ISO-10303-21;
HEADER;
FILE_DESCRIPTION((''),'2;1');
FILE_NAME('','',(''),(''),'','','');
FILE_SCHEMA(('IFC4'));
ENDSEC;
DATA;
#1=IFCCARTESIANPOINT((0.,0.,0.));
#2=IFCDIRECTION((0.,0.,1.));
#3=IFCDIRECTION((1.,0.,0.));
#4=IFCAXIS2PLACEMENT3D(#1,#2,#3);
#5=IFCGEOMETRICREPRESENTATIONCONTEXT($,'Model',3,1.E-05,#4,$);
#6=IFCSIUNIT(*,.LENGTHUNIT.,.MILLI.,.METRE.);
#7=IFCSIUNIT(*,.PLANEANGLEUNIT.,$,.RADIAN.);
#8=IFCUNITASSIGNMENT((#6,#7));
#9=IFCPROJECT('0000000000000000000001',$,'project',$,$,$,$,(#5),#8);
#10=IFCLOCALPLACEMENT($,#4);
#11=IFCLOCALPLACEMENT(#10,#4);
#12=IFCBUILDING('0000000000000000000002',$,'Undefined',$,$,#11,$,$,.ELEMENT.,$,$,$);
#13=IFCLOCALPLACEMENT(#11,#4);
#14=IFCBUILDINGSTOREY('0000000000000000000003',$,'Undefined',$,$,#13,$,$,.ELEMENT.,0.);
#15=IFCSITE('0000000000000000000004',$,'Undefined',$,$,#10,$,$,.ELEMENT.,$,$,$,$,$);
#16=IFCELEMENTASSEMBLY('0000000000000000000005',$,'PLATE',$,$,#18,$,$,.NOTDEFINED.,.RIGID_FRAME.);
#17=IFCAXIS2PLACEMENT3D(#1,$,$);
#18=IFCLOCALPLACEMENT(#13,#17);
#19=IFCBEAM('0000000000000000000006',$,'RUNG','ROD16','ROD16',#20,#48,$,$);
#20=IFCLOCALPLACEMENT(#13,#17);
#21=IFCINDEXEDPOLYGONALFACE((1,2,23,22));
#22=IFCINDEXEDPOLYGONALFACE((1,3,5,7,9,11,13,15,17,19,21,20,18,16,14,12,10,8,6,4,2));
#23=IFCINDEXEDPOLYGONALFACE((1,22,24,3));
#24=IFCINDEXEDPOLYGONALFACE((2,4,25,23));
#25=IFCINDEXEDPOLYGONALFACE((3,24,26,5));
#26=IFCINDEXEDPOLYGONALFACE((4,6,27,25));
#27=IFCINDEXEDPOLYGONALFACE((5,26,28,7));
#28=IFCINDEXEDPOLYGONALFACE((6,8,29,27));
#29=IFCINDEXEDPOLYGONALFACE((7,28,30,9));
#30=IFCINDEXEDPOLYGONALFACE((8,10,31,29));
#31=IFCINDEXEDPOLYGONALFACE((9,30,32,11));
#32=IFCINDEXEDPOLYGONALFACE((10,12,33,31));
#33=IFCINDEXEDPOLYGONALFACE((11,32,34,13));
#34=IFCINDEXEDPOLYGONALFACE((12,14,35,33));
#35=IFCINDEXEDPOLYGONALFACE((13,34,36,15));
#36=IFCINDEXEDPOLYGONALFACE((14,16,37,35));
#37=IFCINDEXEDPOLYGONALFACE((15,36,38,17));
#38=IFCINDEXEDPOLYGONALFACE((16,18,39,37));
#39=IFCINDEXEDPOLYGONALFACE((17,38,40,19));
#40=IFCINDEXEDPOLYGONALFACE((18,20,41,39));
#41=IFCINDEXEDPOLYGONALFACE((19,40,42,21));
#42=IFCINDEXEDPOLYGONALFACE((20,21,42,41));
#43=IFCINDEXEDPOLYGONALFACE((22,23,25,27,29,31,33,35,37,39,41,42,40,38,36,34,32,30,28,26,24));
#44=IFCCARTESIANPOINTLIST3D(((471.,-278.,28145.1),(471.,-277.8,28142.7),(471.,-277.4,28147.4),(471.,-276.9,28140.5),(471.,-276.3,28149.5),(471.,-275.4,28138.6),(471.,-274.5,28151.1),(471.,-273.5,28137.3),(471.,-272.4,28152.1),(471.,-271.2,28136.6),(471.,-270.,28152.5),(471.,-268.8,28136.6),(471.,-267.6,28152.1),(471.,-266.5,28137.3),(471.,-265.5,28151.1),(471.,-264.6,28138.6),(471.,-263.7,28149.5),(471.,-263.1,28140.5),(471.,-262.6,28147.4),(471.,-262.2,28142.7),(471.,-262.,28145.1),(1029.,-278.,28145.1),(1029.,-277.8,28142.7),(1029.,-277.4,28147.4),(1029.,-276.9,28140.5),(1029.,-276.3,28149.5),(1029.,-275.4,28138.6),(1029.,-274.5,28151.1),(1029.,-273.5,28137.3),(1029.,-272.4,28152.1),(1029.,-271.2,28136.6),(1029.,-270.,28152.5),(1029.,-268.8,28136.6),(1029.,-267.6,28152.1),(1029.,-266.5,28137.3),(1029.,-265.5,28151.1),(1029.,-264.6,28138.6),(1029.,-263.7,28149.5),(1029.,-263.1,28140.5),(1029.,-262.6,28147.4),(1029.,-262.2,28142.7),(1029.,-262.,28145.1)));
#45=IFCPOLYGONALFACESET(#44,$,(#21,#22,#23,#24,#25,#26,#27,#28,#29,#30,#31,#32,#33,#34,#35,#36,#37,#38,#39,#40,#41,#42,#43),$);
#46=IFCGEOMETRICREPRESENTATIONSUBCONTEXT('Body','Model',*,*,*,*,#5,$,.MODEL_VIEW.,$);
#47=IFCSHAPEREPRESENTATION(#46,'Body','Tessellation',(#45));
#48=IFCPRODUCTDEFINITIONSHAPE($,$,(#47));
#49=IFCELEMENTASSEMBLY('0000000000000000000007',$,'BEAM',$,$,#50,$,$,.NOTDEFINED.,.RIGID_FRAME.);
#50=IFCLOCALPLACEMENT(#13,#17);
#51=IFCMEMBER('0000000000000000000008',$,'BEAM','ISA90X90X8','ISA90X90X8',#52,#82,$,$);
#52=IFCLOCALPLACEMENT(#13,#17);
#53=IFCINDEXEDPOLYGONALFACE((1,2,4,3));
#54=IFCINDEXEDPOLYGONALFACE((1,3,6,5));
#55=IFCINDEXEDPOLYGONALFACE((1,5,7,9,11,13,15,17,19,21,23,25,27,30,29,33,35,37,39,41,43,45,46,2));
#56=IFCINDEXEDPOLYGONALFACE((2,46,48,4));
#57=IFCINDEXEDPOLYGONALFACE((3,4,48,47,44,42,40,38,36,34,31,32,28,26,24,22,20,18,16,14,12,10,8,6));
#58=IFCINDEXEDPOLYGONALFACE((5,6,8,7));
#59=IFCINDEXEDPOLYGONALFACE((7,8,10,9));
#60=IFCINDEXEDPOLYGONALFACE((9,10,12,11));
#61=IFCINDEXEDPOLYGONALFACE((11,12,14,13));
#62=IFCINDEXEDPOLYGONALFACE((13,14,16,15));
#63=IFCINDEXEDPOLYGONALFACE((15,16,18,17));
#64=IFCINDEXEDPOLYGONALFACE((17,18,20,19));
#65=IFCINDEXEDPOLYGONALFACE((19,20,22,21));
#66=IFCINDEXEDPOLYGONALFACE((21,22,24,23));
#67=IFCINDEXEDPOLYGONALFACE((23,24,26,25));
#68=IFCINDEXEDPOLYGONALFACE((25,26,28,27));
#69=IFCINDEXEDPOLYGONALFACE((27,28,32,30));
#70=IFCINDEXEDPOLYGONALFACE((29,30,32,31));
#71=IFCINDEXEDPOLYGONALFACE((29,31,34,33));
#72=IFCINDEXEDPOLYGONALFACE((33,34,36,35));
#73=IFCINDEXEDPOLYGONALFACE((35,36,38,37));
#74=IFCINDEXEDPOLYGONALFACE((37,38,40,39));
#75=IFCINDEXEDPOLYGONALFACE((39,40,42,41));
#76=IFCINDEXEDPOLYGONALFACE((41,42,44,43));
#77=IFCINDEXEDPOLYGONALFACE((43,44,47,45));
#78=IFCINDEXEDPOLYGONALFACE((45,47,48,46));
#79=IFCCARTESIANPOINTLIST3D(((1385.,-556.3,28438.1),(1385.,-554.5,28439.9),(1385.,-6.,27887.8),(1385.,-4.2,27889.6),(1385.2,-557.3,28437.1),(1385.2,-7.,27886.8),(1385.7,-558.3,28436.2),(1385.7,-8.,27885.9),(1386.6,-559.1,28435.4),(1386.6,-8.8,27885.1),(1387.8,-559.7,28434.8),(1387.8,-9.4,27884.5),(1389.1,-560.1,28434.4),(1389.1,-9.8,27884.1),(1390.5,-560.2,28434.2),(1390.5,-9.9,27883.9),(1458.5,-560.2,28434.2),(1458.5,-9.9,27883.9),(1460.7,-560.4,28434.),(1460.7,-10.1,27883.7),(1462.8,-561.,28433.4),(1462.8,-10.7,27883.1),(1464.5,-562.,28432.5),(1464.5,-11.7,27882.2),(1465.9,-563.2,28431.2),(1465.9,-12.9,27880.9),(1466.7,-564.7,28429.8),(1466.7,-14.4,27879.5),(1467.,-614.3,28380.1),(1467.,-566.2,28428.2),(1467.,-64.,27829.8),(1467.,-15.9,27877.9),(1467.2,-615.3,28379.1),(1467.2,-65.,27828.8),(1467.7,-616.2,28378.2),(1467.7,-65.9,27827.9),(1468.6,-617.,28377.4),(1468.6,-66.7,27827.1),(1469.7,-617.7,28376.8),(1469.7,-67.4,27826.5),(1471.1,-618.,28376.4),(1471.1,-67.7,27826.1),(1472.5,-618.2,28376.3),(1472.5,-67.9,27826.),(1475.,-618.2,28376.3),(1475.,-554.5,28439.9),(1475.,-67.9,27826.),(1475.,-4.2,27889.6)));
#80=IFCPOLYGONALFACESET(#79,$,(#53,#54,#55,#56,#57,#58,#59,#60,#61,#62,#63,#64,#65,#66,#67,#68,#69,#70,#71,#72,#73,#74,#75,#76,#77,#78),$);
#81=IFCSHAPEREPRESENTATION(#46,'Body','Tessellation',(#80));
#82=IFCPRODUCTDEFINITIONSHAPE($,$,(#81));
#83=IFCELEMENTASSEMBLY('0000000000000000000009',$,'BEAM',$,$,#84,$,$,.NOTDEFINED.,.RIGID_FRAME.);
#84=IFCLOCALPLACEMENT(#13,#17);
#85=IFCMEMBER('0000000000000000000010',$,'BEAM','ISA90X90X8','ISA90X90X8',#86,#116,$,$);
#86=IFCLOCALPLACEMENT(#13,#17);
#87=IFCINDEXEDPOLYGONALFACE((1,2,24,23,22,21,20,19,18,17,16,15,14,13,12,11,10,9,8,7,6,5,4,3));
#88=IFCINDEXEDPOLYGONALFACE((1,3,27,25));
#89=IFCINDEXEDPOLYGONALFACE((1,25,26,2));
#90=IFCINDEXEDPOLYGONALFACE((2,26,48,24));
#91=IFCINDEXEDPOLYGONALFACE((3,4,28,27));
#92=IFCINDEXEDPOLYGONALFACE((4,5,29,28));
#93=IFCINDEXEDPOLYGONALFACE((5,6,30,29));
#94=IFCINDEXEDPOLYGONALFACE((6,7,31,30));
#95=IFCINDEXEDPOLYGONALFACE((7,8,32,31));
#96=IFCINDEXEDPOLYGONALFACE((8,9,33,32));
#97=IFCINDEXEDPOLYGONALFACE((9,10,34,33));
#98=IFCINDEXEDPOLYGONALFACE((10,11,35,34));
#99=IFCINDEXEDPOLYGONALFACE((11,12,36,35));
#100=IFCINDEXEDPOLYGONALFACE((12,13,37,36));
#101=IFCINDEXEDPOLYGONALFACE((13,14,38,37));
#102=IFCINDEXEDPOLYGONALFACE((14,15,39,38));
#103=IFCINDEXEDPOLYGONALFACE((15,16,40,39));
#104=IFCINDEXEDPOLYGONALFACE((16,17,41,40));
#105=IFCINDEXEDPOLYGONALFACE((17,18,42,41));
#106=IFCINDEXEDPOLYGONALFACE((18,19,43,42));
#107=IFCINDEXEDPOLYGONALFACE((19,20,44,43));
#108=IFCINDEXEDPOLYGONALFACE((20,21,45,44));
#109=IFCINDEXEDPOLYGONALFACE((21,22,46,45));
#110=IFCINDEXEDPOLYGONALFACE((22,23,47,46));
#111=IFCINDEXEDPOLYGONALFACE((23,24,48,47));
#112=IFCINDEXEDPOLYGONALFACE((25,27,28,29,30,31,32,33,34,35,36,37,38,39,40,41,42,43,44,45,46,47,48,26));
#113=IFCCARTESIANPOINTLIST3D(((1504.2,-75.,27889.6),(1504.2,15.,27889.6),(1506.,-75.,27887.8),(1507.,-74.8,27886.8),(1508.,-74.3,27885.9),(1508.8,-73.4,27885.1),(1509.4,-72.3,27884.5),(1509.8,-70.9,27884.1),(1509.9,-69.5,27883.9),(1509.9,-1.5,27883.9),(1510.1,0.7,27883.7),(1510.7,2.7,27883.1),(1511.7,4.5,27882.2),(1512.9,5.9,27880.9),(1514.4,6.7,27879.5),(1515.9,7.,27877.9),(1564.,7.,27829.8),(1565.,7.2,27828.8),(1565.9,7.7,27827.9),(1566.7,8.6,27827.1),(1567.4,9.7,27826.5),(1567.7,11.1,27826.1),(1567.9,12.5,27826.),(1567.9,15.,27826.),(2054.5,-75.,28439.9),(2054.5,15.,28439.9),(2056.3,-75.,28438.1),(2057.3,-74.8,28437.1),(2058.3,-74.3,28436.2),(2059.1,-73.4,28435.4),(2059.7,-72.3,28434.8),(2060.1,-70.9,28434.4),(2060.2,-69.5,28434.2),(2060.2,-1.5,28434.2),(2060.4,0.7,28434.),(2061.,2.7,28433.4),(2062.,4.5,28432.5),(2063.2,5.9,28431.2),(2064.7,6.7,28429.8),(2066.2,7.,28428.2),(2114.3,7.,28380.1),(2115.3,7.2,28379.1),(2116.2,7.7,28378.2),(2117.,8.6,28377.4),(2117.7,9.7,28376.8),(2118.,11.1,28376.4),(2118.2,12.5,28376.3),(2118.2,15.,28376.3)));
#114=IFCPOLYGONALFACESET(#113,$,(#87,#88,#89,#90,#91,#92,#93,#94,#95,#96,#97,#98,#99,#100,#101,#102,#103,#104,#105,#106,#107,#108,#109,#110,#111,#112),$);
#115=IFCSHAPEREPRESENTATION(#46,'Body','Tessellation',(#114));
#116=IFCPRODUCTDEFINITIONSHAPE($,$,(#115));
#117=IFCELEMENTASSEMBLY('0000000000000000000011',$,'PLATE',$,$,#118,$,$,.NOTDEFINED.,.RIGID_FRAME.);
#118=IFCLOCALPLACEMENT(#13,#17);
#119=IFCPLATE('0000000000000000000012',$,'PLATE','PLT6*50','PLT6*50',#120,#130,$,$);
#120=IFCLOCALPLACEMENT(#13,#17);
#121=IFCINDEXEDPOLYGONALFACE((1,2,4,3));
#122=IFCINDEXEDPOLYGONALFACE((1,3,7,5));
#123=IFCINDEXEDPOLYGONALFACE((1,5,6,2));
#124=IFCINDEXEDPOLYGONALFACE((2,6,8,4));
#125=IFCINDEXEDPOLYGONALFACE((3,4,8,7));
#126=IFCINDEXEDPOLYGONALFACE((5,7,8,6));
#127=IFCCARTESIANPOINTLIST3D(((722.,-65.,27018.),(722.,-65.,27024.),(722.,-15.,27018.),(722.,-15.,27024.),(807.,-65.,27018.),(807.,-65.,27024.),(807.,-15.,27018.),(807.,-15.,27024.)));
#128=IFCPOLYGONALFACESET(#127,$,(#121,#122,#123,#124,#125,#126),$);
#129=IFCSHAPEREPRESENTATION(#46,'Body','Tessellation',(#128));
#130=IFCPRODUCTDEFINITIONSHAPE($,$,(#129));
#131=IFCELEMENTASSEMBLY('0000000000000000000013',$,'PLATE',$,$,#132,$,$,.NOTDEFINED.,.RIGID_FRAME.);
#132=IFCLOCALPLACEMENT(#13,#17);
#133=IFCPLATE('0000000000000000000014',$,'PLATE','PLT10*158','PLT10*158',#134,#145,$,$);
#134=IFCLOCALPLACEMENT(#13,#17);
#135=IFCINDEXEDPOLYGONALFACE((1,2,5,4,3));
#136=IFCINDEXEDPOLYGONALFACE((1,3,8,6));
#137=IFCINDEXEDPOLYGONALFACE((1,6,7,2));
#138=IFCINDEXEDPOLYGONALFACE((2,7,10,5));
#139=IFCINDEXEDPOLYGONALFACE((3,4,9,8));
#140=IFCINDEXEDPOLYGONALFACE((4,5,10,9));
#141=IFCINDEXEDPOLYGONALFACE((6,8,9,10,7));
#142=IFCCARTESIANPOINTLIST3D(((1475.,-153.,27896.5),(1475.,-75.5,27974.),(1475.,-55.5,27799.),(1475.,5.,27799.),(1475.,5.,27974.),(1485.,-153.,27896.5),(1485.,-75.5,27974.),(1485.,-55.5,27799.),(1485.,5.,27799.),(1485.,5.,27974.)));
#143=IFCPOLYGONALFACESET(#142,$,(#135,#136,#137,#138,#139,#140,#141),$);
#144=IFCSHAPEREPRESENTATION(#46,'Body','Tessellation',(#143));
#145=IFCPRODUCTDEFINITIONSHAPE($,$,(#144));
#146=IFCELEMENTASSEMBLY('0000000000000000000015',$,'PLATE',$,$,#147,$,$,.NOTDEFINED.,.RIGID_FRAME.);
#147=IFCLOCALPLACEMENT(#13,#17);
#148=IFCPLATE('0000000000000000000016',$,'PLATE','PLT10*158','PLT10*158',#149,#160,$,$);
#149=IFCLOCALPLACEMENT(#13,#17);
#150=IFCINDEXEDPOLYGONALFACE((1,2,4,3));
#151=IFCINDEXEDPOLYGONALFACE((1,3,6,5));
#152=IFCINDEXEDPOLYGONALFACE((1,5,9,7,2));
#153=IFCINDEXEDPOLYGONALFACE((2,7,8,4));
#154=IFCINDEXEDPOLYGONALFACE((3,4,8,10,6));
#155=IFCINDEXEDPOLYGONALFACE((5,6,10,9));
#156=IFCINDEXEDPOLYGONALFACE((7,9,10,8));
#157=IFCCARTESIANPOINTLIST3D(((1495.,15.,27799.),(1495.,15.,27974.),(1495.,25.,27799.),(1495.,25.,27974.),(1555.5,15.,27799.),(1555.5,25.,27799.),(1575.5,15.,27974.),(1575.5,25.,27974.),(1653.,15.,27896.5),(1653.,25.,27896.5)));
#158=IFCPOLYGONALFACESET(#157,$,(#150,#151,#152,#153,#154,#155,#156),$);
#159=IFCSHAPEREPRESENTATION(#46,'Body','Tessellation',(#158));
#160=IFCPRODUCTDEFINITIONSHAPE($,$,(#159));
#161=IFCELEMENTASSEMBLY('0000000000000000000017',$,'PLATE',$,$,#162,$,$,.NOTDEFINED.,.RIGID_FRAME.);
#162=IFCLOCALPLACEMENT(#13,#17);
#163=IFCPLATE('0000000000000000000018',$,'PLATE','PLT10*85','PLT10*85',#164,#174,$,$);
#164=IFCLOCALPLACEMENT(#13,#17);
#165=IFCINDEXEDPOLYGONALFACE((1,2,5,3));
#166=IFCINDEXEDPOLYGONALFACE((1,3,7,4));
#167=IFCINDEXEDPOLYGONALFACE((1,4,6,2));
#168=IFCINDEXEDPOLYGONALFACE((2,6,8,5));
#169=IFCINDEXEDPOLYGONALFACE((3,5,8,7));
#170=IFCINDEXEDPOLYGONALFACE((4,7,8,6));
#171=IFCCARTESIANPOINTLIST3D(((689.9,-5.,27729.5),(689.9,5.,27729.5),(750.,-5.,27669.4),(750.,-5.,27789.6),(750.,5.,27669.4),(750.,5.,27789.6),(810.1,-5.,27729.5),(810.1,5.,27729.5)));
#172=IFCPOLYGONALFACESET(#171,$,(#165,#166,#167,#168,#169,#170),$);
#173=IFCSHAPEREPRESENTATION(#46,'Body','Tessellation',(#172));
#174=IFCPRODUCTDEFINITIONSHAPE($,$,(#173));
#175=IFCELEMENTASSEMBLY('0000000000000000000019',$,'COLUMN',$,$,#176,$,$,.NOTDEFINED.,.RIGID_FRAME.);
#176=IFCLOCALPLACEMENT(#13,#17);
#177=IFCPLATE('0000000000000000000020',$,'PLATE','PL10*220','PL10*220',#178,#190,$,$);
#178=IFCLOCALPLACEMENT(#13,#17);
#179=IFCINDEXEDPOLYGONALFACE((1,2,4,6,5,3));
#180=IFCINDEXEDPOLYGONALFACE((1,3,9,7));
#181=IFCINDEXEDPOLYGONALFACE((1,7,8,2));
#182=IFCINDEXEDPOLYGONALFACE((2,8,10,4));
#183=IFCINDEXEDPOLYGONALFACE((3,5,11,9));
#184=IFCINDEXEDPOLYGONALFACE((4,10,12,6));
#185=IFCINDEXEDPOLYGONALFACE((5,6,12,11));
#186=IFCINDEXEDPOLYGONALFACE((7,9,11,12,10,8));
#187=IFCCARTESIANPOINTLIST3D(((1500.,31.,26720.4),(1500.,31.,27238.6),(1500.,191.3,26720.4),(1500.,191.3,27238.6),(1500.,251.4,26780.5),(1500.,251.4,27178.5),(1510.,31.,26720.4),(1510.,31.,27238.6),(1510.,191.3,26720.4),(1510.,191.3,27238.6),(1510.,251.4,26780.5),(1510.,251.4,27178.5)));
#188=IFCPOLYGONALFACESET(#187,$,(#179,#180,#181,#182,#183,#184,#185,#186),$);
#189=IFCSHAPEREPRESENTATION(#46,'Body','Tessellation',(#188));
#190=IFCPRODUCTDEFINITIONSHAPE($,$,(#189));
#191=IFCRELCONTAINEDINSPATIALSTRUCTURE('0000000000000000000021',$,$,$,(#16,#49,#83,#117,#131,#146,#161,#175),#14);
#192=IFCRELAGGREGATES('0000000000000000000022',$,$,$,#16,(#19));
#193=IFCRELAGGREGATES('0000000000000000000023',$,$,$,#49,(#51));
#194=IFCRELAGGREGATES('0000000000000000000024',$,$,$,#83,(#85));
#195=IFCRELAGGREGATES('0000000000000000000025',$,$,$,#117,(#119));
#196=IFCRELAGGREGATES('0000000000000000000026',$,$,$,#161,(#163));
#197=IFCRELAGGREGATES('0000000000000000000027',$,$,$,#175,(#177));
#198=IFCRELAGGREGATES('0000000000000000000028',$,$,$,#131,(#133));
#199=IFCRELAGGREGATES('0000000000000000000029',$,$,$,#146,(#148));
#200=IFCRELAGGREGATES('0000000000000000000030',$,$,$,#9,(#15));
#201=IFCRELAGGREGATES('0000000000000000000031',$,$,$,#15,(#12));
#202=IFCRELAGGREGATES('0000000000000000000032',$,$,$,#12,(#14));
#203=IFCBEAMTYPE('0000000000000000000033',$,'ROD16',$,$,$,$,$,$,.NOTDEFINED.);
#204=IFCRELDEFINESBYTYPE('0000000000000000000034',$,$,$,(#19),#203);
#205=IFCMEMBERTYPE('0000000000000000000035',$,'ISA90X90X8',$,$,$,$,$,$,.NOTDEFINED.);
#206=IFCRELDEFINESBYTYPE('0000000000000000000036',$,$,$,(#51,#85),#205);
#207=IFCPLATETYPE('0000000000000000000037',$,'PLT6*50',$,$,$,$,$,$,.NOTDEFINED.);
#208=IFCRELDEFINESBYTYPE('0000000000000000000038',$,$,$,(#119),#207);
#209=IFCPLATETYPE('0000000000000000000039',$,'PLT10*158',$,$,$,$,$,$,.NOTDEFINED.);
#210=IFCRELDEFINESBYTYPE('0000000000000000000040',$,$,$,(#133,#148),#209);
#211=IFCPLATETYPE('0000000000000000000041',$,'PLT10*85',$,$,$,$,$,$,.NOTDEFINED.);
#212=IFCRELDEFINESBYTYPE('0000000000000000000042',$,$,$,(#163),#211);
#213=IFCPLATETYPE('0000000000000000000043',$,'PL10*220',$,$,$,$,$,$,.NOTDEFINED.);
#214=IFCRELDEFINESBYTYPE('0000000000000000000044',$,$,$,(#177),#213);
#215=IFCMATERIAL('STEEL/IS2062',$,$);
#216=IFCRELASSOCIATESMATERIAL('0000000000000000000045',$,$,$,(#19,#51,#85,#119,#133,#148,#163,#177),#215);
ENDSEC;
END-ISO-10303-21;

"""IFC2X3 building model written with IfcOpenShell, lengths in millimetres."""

from ifc_helpers import new_model, si_unit, frame, origin_with_axes, origin_2d_with_axis, place, context, subcontext, project, spatial, polyline, circle, l_section, outline, extrude, material, type_object, element, aggregate, save


model = new_model("IFC2X3")

# Units and contexts
model_context = context("Model", 3, precision=1e-05, world=origin_with_axes())
body_context = subcontext(model_context, "Body", "Model", "MODEL_VIEW")
ifc_project = project(units=[si_unit("LENGTHUNIT", "METRE", prefix="MILLI"), si_unit("PLANEANGLEUNIT", "RADIAN")], contexts=[model_context])

# Site, building, storey
site_placement = place(None, origin_with_axes())
site = spatial("IfcSite", under=ifc_project, at=site_placement, Name="Undefined", CompositionType="ELEMENT")
building_placement = place(site_placement, origin_with_axes())
building = spatial("IfcBuilding", under=site, at=building_placement, Name="Undefined", CompositionType="ELEMENT")
storey_placement = place(building_placement, origin_with_axes())
storey = spatial("IfcBuildingStorey", under=building, at=storey_placement, Name="Undefined", CompositionType="ELEMENT", Elevation=0.0)

# Shared definitions
ifc_material_1 = material(Name="STEEL/IS2062")

# Element assembly, beam
assembly_1_placement = place(storey_placement, origin_with_axes())
assembly_1 = element("IfcElementAssembly", 1, at=assembly_1_placement, inside=storey, Name="PLATE", AssemblyPlace="NOTDEFINED", PredefinedType="RIGID_FRAME")
beam_type_1 = type_object("IfcBeamType", Name="ROD16", PredefinedType="NOTDEFINED")
beam_1_placement = place(assembly_1_placement, frame((471.0, -270.0, 28144.5), z_axis=(0.0, 1.0, 0.0), x_axis=(1.0, 0.0, 0.0)))
beam_1 = element("IfcBeam", 2, at=beam_1_placement, type_object=beam_type_1, material=ifc_material_1, Name="RUNG", Description="ROD16", ObjectType="ROD16", context=body_context, shape_type="SweptSolid", body=[
    extrude(circle(Radius=8.0, at=origin_2d_with_axis()), frame((558.0, 0.0, 0.0), z_axis=(-1.0, 0.0, 0.0), x_axis=(0.0, -1.0, 0.0)), (0.0, 0.0, 1.0), 558.0),
])
aggregate(assembly_1, [beam_1])

# Element assemblies, members
assembly_2_placement = place(storey_placement, origin_with_axes())
assembly_2 = element("IfcElementAssembly", 3, at=assembly_2_placement, inside=storey, Name="BEAM", AssemblyPlace="NOTDEFINED", PredefinedType="RIGID_FRAME")
member_type_1 = type_object("IfcMemberType", Name="ISA90X90X8", PredefinedType="NOTDEFINED")
member_1_placement = place(assembly_2_placement, frame((1430.0, -36.1, 27857.8), z_axis=(-1.0, 0.0, 0.0), x_axis=(0.0, -0.707107, 0.707107)))
member_1 = element("IfcMember", 4, at=member_1_placement, type_object=member_type_1, material=ifc_material_1, Name="BEAM", Description="ISA90X90X8", ObjectType="ISA90X90X8", context=body_context, shape_type="SweptSolid", body=[
    extrude(l_section(Depth=90.0, Width=90.0, Thickness=8.0, FilletRadius=8.5, EdgeRadius=5.5, at=origin_2d_with_axis()), frame((778.2, 0.0, 0.0), z_axis=(-1.0, 0.0, 0.0), x_axis=(0.0, -1.0, 0.0)), (0.0, 0.0, 1.0), 778.2),
])
aggregate(assembly_2, [member_1])
assembly_3_placement = place(storey_placement, origin_with_axes())
assembly_3 = element("IfcElementAssembly", 5, at=assembly_3_placement, inside=storey, Name="BEAM", AssemblyPlace="NOTDEFINED", PredefinedType="RIGID_FRAME")
member_2_placement = place(assembly_3_placement, frame((1536.1, -30.0, 27857.8), z_axis=(0.0, -1.0, 0.0), x_axis=(0.707107, 0.0, 0.707107)))
member_2 = element("IfcMember", 6, at=member_2_placement, type_object=member_type_1, material=ifc_material_1, Name="BEAM", Description="ISA90X90X8", ObjectType="ISA90X90X8", context=body_context, shape_type="SweptSolid", body=[
    extrude(l_section(Depth=90.0, Width=90.0, Thickness=8.0, FilletRadius=8.5, EdgeRadius=5.5, at=origin_2d_with_axis()), frame((778.2, 0.0, 0.0), z_axis=(-1.0, 0.0, 0.0), x_axis=(0.0, -1.0, 0.0)), (0.0, 0.0, 1.0), 778.2),
])
aggregate(assembly_3, [member_2])

# Element assemblies, plates
assembly_4_placement = place(storey_placement, origin_with_axes())
assembly_4 = element("IfcElementAssembly", 7, at=assembly_4_placement, inside=storey, Name="PLATE", AssemblyPlace="NOTDEFINED", PredefinedType="RIGID_FRAME")
plate_type_1 = type_object("IfcPlateType", Name="PLT6*50", PredefinedType="NOTDEFINED")
plate_1_placement = place(assembly_4_placement, frame((807.0, -65.0, 27021.0), z_axis=(0.0, 0.0, -1.0), x_axis=(-1.0, 0.0, 0.0)))
plate_1 = element("IfcPlate", 8, at=plate_1_placement, type_object=plate_type_1, material=ifc_material_1, Name="PLATE", Description="PLT6*50", ObjectType="PLT6*50", context=body_context, shape_type="SweptSolid", body=[
    extrude(outline(polyline([(0.0, 0.0), (85.0, 0.0), (85.0, 50.0), (0.0, 50.0), (0.0, 0.0)])), frame((0.0, 0.0, -3.0), z_axis=(0.0, 0.0, 1.0), x_axis=(1.0, 0.0, 0.0)), (0.0, 0.0, 1.0), 6.0),
])
aggregate(assembly_4, [plate_1])
assembly_5_placement = place(storey_placement, origin_with_axes())
assembly_5 = element("IfcElementAssembly", 9, at=assembly_5_placement, inside=storey, Name="PLATE", AssemblyPlace="NOTDEFINED", PredefinedType="RIGID_FRAME")
plate_type_2 = type_object("IfcPlateType", Name="PLT10*158", PredefinedType="NOTDEFINED")
plate_2_placement = place(assembly_5_placement, frame((1480.0, 5.0, 27799.0), z_axis=(1.0, 0.0, 0.0), x_axis=(0.0, 0.0, 1.0)))
plate_2 = element("IfcPlate", 10, at=plate_2_placement, type_object=plate_type_2, material=ifc_material_1, Name="PLATE", Description="PLT10*158", ObjectType="PLT10*158", context=body_context, shape_type="SweptSolid", body=[
    extrude(outline(polyline([(0.0, 0.0), (175.0, 0.0), (175.0, 80.5), (97.5, 158.0), (97.5, 158.0), (0.0, 60.5), (0.0, 0.0)])), frame((0.0, 0.0, -5.0), z_axis=(0.0, 0.0, 1.0), x_axis=(1.0, 0.0, 0.0)), (0.0, 0.0, 1.0), 10.0),
])
assembly_6_placement = place(storey_placement, origin_with_axes())
assembly_6 = element("IfcElementAssembly", 11, at=assembly_6_placement, inside=storey, Name="PLATE", AssemblyPlace="NOTDEFINED", PredefinedType="RIGID_FRAME")
plate_3_placement = place(assembly_6_placement, frame((1495.0, 20.0, 27799.0), z_axis=(0.0, 1.0, 0.0), x_axis=(0.0, 0.0, 1.0)))
plate_3 = element("IfcPlate", 12, at=plate_3_placement, type_object=plate_type_2, material=ifc_material_1, Name="PLATE", Description="PLT10*158", ObjectType="PLT10*158", context=body_context, shape_type="SweptSolid", body=[
    extrude(outline(polyline([(0.0, 0.0), (175.0, 0.0), (175.0, 80.5), (97.5, 158.0), (97.5, 158.0), (0.0, 60.5), (0.0, 0.0)])), frame((0.0, 0.0, -5.0), z_axis=(0.0, 0.0, 1.0), x_axis=(1.0, 0.0, 0.0)), (0.0, 0.0, 1.0), 10.0),
])
assembly_7_placement = place(storey_placement, origin_with_axes())
assembly_7 = element("IfcElementAssembly", 13, at=assembly_7_placement, inside=storey, Name="PLATE", AssemblyPlace="NOTDEFINED", PredefinedType="RIGID_FRAME")
plate_type_3 = type_object("IfcPlateType", Name="PLT10*85", PredefinedType="NOTDEFINED")
plate_4_placement = place(assembly_7_placement, frame((750.0, 0.0, 27789.6), z_axis=(0.0, -1.0, 0.0), x_axis=(-0.707107, 0.0, -0.707107)))
plate_4 = element("IfcPlate", 14, at=plate_4_placement, type_object=plate_type_3, material=ifc_material_1, Name="PLATE", Description="PLT10*85", ObjectType="PLT10*85", context=body_context, shape_type="SweptSolid", body=[
    extrude(outline(polyline([(0.0, 0.0), (85.0, 0.0), (85.0, 85.0), (0.0, 85.0), (0.0, 0.0)])), frame((0.0, 0.0, -5.0), z_axis=(0.0, 0.0, 1.0), x_axis=(1.0, 0.0, 0.0)), (0.0, 0.0, 1.0), 10.0),
])
aggregate(assembly_7, [plate_4])

# Element assembly, plate
assembly_8_placement = place(storey_placement, origin_with_axes())
assembly_8 = element("IfcElementAssembly", 15, at=assembly_8_placement, inside=storey, Name="COLUMN", AssemblyPlace="NOTDEFINED", PredefinedType="RIGID_FRAME")
plate_type_4 = type_object("IfcPlateType", Name="PL10*220", PredefinedType="NOTDEFINED")
plate_5_placement = place(assembly_8_placement, frame((1505.0, 31.0, 27238.6), z_axis=(1.0, 0.0, 0.0), x_axis=(0.0, 0.0, -1.0)))
plate_5 = element("IfcPlate", 16, at=plate_5_placement, type_object=plate_type_4, material=ifc_material_1, Name="PLATE", Description="PL10*220", ObjectType="PL10*220", context=body_context, shape_type="SweptSolid", body=[
    extrude(outline(polyline([(0.0, 0.0), (518.3, 0.0), (518.3, 160.3), (458.2, 220.4), (60.1, 220.4), (0.0, 160.3), (0.0, 0.0)])), frame((0.0, 0.0, -5.0), z_axis=(0.0, 0.0, 1.0), x_axis=(1.0, 0.0, 0.0)), (0.0, 0.0, 1.0), 10.0),
])
aggregate(assembly_8, [plate_5])

aggregate(assembly_5, [plate_2])

aggregate(assembly_6, [plate_3])

save(model, "model.ifc")
